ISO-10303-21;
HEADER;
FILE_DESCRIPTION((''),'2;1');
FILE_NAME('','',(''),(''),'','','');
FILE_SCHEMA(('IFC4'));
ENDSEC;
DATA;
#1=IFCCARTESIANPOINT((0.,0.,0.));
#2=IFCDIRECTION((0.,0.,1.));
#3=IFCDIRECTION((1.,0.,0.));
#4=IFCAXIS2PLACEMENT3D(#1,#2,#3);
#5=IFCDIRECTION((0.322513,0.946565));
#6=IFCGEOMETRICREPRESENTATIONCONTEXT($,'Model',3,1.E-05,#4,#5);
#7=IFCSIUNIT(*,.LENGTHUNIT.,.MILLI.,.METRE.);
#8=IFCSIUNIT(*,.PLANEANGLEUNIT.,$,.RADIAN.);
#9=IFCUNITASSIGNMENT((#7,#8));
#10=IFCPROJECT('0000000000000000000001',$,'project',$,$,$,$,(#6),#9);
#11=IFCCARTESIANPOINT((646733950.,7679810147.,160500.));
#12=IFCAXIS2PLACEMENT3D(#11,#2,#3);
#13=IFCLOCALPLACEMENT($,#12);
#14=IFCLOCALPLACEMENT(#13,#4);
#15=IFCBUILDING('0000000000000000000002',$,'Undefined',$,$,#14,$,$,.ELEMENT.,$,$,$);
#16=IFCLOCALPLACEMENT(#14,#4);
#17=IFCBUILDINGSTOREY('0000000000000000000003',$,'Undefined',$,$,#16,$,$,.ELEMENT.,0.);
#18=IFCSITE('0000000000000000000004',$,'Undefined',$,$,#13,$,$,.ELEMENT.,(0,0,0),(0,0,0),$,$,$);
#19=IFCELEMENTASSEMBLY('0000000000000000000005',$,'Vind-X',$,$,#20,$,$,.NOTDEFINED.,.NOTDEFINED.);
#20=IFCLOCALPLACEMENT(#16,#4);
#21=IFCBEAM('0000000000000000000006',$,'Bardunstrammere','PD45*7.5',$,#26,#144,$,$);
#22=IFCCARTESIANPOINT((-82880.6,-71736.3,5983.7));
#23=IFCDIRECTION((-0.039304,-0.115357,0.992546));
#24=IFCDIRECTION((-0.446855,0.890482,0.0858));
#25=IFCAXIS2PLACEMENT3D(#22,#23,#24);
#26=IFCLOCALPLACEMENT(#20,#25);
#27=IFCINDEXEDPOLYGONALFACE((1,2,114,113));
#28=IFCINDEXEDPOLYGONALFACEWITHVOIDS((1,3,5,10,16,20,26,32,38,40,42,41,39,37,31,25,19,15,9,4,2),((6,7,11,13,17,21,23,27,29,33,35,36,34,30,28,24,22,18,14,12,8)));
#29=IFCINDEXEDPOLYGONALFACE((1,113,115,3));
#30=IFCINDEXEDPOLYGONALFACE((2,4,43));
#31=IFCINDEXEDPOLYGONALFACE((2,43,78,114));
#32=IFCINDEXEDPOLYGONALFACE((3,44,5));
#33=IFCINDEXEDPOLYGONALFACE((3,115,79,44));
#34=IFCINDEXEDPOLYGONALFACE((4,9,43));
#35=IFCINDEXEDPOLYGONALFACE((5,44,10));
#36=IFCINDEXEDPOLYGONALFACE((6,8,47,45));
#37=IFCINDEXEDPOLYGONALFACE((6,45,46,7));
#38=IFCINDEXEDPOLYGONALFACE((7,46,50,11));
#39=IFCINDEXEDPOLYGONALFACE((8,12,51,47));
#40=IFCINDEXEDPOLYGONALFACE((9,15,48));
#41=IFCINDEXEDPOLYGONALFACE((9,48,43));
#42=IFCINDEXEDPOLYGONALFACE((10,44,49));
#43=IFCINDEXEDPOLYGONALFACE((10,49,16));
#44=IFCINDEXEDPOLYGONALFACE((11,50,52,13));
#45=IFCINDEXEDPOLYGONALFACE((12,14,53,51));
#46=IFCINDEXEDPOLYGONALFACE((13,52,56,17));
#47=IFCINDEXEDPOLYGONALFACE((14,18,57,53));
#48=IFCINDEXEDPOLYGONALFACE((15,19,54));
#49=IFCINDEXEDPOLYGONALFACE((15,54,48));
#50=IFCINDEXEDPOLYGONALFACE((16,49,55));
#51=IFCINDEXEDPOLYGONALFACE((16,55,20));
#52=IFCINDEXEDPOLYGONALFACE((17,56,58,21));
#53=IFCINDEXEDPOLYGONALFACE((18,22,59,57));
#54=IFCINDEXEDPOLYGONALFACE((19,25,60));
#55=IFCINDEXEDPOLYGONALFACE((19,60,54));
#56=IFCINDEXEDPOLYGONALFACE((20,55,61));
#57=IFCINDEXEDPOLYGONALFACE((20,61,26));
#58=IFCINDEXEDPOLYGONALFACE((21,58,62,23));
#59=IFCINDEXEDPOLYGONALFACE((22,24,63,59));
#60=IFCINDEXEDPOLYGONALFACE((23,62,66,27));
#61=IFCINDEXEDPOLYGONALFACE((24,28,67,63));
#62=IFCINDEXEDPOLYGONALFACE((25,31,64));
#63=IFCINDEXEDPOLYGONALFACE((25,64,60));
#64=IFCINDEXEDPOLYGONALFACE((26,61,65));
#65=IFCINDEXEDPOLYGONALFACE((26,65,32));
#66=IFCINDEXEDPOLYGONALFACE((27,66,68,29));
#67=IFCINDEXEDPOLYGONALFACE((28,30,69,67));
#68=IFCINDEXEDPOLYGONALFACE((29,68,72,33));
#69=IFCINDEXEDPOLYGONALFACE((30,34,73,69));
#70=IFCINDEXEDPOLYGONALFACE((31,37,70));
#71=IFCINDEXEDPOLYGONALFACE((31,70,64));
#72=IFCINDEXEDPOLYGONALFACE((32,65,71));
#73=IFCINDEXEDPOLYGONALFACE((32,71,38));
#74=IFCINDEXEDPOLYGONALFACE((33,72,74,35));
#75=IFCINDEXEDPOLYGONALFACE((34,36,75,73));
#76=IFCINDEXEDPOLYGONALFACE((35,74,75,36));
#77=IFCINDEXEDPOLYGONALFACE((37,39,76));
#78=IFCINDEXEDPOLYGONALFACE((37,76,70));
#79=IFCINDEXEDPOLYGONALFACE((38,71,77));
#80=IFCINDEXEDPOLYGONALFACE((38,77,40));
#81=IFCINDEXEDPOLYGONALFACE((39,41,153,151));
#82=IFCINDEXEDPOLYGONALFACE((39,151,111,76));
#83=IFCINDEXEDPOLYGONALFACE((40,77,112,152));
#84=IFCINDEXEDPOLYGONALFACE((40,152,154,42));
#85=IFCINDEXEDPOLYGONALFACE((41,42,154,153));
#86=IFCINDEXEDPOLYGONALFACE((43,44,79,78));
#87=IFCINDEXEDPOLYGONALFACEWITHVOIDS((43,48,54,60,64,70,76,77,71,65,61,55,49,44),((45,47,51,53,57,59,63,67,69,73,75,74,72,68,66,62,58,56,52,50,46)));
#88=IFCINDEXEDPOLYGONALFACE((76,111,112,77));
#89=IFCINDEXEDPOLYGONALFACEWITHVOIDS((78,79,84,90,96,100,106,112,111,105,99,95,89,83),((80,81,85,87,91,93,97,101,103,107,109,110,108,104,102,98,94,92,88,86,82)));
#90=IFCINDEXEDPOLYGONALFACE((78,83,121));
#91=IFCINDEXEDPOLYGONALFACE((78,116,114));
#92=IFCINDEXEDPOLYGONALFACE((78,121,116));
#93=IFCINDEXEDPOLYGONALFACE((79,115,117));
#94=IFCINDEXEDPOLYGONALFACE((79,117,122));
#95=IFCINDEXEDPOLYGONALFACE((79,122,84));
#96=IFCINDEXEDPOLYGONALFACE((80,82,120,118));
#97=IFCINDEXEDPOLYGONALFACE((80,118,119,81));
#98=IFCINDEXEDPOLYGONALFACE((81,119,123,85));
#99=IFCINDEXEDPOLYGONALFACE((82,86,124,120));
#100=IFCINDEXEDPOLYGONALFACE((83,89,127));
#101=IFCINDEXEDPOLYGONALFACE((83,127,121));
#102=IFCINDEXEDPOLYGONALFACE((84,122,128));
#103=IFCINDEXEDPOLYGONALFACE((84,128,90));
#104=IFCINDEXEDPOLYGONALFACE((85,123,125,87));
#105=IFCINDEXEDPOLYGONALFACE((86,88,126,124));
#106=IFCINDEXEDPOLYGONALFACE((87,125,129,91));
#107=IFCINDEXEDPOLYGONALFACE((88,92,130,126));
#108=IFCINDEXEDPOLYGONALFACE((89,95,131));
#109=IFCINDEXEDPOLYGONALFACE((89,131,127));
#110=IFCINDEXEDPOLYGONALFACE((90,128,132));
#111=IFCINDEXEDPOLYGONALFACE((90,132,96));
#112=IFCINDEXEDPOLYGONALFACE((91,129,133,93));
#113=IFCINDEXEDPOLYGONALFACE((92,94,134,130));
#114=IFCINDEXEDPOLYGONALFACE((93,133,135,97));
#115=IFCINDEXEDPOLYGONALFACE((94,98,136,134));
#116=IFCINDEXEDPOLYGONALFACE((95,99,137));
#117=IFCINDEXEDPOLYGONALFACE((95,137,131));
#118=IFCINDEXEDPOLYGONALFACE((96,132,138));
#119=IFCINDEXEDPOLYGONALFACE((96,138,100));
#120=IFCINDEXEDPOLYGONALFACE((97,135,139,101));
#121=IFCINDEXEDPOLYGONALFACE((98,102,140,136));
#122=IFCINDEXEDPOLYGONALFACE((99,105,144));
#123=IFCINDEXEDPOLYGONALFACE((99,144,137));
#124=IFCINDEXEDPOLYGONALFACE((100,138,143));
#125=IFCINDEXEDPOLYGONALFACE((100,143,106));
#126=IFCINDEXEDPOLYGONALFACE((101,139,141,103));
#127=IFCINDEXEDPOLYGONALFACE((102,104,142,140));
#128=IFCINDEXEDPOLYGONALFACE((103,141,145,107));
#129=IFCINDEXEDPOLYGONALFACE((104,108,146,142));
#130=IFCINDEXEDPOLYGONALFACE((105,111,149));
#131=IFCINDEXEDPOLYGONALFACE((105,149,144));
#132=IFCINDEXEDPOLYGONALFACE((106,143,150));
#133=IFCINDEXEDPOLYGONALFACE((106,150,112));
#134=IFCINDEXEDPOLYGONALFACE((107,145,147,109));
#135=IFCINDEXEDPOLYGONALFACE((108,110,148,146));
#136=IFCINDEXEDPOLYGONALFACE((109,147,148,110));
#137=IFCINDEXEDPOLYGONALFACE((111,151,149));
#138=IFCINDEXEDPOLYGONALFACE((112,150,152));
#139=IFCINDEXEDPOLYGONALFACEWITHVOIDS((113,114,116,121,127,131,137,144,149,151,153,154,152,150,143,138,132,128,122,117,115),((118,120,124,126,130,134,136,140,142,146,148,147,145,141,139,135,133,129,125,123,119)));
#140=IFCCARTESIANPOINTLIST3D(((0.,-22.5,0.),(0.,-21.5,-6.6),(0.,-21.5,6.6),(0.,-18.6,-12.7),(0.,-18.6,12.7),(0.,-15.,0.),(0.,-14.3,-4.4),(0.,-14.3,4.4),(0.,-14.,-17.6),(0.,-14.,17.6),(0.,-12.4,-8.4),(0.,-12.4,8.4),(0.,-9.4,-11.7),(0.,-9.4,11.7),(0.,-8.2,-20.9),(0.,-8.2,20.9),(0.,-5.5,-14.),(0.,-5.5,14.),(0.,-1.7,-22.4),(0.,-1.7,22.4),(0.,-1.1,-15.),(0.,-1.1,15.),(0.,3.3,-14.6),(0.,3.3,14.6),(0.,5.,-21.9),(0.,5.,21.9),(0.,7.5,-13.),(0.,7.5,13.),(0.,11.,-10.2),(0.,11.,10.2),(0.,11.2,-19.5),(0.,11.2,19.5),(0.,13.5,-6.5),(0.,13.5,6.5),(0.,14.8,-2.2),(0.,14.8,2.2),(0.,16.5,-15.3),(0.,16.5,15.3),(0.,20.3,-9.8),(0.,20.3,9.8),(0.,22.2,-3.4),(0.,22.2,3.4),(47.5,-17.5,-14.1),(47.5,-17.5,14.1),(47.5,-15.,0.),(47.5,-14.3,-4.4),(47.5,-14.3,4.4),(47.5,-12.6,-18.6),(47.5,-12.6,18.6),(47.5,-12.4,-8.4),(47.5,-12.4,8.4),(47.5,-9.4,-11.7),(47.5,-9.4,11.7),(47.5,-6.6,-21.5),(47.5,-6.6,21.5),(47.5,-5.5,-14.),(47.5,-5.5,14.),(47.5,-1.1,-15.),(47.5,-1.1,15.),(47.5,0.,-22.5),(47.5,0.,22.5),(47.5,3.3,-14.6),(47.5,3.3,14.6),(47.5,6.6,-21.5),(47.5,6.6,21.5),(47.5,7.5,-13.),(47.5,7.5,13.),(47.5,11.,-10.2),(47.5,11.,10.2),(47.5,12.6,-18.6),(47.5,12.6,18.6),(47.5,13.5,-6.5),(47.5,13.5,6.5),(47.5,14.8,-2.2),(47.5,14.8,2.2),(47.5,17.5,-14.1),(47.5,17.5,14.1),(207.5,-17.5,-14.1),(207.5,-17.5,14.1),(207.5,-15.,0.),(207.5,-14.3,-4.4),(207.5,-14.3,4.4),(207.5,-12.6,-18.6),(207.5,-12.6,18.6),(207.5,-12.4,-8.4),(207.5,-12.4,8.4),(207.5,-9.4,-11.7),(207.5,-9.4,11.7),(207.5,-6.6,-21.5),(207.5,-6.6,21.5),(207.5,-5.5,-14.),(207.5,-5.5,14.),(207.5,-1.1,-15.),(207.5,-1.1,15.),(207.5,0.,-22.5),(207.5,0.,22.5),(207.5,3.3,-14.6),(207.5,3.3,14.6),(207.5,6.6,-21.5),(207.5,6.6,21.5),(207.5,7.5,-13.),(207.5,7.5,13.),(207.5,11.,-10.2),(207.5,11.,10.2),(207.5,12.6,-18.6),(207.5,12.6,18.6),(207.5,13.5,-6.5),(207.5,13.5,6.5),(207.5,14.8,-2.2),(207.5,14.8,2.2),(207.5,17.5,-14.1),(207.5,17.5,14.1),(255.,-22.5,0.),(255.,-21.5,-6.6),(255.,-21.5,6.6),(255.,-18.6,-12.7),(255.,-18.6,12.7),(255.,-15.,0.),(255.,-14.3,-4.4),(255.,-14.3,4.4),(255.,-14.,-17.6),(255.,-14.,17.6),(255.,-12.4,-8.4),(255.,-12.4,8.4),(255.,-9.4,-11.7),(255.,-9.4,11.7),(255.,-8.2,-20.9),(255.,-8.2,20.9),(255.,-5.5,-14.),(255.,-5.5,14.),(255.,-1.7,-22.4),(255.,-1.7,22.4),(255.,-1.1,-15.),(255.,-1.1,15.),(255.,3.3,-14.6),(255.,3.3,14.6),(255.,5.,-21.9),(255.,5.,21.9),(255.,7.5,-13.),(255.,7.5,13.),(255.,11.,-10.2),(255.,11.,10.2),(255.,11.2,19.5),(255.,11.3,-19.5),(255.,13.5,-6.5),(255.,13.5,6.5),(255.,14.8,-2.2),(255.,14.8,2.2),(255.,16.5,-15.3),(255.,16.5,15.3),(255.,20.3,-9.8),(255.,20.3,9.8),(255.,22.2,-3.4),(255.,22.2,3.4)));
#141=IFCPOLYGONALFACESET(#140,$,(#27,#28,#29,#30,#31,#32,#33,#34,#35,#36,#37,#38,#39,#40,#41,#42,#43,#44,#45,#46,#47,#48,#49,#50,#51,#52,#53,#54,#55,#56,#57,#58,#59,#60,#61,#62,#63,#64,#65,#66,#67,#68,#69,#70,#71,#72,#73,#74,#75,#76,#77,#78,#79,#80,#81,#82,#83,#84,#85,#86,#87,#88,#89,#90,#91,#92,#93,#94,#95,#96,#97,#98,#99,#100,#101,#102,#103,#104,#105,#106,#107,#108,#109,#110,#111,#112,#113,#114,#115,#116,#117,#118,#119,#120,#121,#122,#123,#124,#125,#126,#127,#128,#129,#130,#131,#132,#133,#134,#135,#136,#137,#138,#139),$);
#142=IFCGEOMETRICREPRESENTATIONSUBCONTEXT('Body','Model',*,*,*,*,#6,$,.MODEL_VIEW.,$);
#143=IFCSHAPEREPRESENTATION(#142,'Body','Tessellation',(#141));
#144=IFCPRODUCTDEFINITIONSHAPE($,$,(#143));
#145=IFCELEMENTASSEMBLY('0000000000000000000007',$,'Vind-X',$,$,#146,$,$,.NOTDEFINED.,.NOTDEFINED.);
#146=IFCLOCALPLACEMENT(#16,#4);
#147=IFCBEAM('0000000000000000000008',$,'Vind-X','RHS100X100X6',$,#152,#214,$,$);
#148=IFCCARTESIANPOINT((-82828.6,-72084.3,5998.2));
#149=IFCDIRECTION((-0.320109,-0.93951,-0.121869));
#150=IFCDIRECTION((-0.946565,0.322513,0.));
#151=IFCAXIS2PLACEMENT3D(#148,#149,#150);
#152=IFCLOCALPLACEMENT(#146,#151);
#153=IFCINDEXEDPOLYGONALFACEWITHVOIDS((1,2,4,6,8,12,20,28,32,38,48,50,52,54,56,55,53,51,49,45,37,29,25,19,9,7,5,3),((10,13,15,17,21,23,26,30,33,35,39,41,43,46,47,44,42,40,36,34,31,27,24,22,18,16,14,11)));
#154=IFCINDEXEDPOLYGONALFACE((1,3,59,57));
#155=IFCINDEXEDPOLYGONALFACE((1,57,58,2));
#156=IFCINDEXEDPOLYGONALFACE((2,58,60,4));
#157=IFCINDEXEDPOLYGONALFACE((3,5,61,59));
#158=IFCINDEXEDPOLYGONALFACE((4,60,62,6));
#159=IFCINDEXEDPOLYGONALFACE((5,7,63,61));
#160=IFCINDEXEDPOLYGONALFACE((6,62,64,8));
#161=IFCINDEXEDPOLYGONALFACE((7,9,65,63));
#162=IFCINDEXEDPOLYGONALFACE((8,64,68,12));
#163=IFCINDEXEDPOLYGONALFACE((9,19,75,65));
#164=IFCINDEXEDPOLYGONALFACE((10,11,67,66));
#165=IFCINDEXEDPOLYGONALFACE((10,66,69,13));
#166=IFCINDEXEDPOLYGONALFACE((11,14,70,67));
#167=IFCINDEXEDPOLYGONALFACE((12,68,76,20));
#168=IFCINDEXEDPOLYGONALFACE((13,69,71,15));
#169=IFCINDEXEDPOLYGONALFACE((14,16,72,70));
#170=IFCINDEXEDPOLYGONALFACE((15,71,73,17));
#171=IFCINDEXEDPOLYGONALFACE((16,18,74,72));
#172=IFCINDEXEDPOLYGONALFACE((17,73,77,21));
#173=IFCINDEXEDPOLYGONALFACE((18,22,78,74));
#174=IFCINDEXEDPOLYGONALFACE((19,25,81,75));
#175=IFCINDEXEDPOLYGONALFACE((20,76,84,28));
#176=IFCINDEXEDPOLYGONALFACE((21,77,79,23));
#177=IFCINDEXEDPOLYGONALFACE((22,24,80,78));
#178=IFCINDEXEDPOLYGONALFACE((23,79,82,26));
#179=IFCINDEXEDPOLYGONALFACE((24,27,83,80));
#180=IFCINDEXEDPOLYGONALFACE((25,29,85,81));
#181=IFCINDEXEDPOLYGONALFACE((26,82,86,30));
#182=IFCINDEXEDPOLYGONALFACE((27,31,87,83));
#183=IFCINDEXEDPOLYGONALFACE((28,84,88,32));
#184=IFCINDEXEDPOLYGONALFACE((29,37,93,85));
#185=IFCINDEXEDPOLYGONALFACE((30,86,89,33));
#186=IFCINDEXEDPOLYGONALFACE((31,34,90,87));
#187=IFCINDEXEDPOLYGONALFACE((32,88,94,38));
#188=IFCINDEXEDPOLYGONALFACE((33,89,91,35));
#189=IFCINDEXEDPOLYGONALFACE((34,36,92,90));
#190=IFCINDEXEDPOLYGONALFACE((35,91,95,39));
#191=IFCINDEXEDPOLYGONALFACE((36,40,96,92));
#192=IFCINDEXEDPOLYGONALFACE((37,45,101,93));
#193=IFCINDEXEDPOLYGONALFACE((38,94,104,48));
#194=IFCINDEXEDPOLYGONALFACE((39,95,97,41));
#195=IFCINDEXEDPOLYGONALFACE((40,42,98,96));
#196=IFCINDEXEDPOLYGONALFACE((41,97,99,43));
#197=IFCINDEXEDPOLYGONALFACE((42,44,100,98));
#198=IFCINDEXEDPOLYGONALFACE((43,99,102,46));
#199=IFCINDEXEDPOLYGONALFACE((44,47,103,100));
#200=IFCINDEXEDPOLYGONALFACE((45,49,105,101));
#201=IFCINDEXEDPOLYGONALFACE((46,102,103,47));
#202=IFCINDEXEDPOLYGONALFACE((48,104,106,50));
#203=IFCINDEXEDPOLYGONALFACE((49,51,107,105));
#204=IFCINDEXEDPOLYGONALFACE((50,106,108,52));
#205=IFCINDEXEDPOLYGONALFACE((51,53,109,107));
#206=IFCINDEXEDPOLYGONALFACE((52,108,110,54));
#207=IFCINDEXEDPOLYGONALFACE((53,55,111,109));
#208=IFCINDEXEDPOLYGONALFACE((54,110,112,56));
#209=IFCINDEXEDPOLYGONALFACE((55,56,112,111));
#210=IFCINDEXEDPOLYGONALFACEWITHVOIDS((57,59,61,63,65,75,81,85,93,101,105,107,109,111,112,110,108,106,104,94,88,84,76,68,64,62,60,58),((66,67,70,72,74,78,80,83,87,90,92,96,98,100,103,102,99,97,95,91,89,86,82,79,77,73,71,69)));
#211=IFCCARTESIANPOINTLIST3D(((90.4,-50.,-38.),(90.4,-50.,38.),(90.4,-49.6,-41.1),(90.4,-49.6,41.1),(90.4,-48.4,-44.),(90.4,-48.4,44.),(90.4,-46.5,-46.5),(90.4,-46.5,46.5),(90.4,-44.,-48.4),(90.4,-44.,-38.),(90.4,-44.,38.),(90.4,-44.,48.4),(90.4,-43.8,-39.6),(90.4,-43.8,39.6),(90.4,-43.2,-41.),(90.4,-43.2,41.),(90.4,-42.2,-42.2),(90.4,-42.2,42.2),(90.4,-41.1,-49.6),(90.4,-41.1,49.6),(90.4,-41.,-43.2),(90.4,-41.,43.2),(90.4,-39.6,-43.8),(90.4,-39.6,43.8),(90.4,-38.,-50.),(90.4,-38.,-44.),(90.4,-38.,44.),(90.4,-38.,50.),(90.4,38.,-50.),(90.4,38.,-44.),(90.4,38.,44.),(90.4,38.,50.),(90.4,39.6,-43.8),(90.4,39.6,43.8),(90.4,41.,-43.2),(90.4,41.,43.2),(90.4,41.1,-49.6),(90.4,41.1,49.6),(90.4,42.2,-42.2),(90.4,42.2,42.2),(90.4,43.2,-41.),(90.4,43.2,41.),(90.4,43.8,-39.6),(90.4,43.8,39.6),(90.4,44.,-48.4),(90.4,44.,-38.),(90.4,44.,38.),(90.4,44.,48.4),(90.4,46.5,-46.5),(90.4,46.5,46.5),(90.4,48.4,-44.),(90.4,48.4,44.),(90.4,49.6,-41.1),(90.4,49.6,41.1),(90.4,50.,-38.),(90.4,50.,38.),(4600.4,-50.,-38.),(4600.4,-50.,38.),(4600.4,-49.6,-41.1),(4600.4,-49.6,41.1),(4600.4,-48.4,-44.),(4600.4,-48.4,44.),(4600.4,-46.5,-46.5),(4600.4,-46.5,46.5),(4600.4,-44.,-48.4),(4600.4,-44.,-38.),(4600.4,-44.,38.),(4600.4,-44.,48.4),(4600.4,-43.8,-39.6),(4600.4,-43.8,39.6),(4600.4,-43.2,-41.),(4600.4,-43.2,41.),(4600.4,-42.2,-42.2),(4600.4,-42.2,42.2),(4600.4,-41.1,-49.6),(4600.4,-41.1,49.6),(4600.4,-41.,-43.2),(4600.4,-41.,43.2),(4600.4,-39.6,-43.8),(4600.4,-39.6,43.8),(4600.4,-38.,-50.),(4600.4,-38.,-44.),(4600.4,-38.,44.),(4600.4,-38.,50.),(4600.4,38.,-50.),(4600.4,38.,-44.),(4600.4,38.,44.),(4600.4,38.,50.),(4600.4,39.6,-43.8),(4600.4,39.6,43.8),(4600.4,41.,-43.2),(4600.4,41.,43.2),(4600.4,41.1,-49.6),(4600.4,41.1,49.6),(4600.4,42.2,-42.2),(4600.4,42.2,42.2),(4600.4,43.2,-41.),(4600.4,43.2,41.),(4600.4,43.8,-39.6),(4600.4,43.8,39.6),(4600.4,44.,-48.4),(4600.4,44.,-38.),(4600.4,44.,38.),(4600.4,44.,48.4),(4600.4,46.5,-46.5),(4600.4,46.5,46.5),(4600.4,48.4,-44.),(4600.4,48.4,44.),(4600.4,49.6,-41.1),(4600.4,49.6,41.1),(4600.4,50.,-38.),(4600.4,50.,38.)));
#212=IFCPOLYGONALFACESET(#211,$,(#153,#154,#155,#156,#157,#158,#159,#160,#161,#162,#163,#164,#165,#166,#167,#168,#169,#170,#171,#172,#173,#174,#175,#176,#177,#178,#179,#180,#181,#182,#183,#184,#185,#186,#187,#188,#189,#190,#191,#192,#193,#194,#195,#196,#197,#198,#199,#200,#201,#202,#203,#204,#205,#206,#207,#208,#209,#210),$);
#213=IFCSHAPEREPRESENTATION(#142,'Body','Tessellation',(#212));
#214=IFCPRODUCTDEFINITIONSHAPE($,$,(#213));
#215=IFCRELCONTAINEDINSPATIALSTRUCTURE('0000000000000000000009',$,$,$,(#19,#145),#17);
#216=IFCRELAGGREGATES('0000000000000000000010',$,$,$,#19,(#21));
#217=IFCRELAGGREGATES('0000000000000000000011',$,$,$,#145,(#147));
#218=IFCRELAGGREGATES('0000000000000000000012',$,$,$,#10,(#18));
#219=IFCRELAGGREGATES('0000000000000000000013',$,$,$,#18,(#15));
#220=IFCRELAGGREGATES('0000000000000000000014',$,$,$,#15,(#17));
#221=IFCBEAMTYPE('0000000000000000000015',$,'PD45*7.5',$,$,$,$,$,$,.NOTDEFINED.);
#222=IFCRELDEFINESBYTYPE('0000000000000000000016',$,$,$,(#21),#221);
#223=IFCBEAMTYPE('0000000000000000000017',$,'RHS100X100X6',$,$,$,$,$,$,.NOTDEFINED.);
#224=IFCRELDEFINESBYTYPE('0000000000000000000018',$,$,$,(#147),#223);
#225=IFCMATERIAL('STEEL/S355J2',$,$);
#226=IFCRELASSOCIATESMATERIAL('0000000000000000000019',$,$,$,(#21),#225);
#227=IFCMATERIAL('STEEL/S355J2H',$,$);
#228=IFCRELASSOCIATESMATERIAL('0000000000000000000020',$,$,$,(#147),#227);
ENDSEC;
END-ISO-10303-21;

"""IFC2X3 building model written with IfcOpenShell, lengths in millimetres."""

from ifc_helpers import new_model, si_unit, direction, frame, origin_with_axes, origin_2d_with_axis, place, context, subcontext, project, spatial, rectangle, hollow_rectangle, hollow_circle, extrude, boolean, clip, halfspace, material, type_object, element, aggregate, save


model = new_model("IFC2X3")

# Units and contexts
model_context = context("Model", 3, precision=1e-05, world=origin_with_axes(), true_north=direction((0.322513, 0.946565)))
body_context = subcontext(model_context, "Body", "Model", "MODEL_VIEW")
ifc_project = project(units=[si_unit("LENGTHUNIT", "METRE", prefix="MILLI"), si_unit("PLANEANGLEUNIT", "RADIAN")], contexts=[model_context])

# Site, building, storey
site_placement = place(None, frame((646733950.0, 7679810147.0, 160500.0), z_axis=(0.0, 0.0, 1.0), x_axis=(1.0, 0.0, 0.0)))
site = spatial("IfcSite", under=ifc_project, at=site_placement, Name="Undefined", CompositionType="ELEMENT", RefLatitude=(0, 0, 0), RefLongitude=(0, 0, 0))
building_placement = place(site_placement, origin_with_axes())
building = spatial("IfcBuilding", under=site, at=building_placement, Name="Undefined", CompositionType="ELEMENT")
storey_placement = place(building_placement, origin_with_axes())
storey = spatial("IfcBuildingStorey", under=building, at=storey_placement, Name="Undefined", CompositionType="ELEMENT", Elevation=0.0)

# Shared definitions
ifc_material_1 = material(Name="STEEL/S355J2H")

# Element assembly, beam
assembly_1_placement = place(storey_placement, origin_with_axes())
assembly_1 = element("IfcElementAssembly", 1, at=assembly_1_placement, inside=storey, Name="Vind-X", AssemblyPlace="NOTDEFINED", PredefinedType="NOTDEFINED")
ifc_material_2 = material(Name="STEEL/S355J2")
beam_type_1 = type_object("IfcBeamType", Name="PD45*7.5", PredefinedType="NOTDEFINED")
beam_1_placement = place(assembly_1_placement, frame((-82880.6, -71736.3, 5983.7), z_axis=(-0.039304, -0.115357, 0.992546), x_axis=(-0.446855, 0.890482, 0.0858)))
beam_1 = element("IfcBeam", 2, at=beam_1_placement, type_object=beam_type_1, material=ifc_material_2, Name="Bardunstrammere", Description="PD45*7.5", context=body_context, shape_type="CSG", body=[
    boolean("DIFFERENCE", extrude(hollow_circle(Radius=22.5, WallThickness=7.5, at=origin_2d_with_axis()), frame((255.0, 0.0, 0.0), z_axis=(-1.0, 0.0, 0.0), x_axis=(0.0, -1.0, 0.0)), (0.0, 0.0, 1.0), 255.0), extrude(rectangle(XDim=35.0, YDim=90.0, at=origin_2d_with_axis()), frame((207.5, 0.0, 0.0), z_axis=(-1.0, 0.0, 0.0), x_axis=(0.0, -1.0, 0.0)), (0.0, 0.0, 1.0), 160.0)),
])

# Element assembly, beam
beam_type_2 = type_object("IfcBeamType", Name="RHS100X100X6", PredefinedType="NOTDEFINED")
assembly_2_placement = place(storey_placement, origin_with_axes())
assembly_2 = element("IfcElementAssembly", 3, at=assembly_2_placement, inside=storey, Name="Vind-X", AssemblyPlace="NOTDEFINED", PredefinedType="NOTDEFINED")
beam_2_placement = place(assembly_2_placement, frame((-82828.6, -72084.3, 5998.2), z_axis=(-0.320109, -0.93951, -0.121869), x_axis=(-0.946565, 0.322513, 0.0)))
beam_2 = element("IfcBeam", 4, at=beam_2_placement, type_object=beam_type_2, material=ifc_material_1, Name="Vind-X", Description="RHS100X100X6", context=body_context, shape_type="Clipping", body=[
    clip(clip(extrude(hollow_rectangle(XDim=100.0, YDim=100.0, WallThickness=6.0, InnerFilletRadius=6.0, OuterFilletRadius=12.0, at=origin_2d_with_axis()), frame((4690.0, 0.0, 0.0), z_axis=(-1.0, 0.0, 0.0), x_axis=(0.0, -1.0, 0.0)), (0.0, 0.0, 1.0), 4690.0), halfspace(frame((4600.4, 7.5, 0.0), z_axis=(-1.0, 0.0, 0.0), x_axis=(0.0, 0.0, -1.0)), True)), halfspace(frame((90.4, 7.5, 0.0), z_axis=(1.0, 0.0, 0.0), x_axis=(0.0, 0.0, 1.0)), True)),
])

aggregate(assembly_1, [beam_1])
aggregate(assembly_2, [beam_2])

save(model, "model.ifc")
